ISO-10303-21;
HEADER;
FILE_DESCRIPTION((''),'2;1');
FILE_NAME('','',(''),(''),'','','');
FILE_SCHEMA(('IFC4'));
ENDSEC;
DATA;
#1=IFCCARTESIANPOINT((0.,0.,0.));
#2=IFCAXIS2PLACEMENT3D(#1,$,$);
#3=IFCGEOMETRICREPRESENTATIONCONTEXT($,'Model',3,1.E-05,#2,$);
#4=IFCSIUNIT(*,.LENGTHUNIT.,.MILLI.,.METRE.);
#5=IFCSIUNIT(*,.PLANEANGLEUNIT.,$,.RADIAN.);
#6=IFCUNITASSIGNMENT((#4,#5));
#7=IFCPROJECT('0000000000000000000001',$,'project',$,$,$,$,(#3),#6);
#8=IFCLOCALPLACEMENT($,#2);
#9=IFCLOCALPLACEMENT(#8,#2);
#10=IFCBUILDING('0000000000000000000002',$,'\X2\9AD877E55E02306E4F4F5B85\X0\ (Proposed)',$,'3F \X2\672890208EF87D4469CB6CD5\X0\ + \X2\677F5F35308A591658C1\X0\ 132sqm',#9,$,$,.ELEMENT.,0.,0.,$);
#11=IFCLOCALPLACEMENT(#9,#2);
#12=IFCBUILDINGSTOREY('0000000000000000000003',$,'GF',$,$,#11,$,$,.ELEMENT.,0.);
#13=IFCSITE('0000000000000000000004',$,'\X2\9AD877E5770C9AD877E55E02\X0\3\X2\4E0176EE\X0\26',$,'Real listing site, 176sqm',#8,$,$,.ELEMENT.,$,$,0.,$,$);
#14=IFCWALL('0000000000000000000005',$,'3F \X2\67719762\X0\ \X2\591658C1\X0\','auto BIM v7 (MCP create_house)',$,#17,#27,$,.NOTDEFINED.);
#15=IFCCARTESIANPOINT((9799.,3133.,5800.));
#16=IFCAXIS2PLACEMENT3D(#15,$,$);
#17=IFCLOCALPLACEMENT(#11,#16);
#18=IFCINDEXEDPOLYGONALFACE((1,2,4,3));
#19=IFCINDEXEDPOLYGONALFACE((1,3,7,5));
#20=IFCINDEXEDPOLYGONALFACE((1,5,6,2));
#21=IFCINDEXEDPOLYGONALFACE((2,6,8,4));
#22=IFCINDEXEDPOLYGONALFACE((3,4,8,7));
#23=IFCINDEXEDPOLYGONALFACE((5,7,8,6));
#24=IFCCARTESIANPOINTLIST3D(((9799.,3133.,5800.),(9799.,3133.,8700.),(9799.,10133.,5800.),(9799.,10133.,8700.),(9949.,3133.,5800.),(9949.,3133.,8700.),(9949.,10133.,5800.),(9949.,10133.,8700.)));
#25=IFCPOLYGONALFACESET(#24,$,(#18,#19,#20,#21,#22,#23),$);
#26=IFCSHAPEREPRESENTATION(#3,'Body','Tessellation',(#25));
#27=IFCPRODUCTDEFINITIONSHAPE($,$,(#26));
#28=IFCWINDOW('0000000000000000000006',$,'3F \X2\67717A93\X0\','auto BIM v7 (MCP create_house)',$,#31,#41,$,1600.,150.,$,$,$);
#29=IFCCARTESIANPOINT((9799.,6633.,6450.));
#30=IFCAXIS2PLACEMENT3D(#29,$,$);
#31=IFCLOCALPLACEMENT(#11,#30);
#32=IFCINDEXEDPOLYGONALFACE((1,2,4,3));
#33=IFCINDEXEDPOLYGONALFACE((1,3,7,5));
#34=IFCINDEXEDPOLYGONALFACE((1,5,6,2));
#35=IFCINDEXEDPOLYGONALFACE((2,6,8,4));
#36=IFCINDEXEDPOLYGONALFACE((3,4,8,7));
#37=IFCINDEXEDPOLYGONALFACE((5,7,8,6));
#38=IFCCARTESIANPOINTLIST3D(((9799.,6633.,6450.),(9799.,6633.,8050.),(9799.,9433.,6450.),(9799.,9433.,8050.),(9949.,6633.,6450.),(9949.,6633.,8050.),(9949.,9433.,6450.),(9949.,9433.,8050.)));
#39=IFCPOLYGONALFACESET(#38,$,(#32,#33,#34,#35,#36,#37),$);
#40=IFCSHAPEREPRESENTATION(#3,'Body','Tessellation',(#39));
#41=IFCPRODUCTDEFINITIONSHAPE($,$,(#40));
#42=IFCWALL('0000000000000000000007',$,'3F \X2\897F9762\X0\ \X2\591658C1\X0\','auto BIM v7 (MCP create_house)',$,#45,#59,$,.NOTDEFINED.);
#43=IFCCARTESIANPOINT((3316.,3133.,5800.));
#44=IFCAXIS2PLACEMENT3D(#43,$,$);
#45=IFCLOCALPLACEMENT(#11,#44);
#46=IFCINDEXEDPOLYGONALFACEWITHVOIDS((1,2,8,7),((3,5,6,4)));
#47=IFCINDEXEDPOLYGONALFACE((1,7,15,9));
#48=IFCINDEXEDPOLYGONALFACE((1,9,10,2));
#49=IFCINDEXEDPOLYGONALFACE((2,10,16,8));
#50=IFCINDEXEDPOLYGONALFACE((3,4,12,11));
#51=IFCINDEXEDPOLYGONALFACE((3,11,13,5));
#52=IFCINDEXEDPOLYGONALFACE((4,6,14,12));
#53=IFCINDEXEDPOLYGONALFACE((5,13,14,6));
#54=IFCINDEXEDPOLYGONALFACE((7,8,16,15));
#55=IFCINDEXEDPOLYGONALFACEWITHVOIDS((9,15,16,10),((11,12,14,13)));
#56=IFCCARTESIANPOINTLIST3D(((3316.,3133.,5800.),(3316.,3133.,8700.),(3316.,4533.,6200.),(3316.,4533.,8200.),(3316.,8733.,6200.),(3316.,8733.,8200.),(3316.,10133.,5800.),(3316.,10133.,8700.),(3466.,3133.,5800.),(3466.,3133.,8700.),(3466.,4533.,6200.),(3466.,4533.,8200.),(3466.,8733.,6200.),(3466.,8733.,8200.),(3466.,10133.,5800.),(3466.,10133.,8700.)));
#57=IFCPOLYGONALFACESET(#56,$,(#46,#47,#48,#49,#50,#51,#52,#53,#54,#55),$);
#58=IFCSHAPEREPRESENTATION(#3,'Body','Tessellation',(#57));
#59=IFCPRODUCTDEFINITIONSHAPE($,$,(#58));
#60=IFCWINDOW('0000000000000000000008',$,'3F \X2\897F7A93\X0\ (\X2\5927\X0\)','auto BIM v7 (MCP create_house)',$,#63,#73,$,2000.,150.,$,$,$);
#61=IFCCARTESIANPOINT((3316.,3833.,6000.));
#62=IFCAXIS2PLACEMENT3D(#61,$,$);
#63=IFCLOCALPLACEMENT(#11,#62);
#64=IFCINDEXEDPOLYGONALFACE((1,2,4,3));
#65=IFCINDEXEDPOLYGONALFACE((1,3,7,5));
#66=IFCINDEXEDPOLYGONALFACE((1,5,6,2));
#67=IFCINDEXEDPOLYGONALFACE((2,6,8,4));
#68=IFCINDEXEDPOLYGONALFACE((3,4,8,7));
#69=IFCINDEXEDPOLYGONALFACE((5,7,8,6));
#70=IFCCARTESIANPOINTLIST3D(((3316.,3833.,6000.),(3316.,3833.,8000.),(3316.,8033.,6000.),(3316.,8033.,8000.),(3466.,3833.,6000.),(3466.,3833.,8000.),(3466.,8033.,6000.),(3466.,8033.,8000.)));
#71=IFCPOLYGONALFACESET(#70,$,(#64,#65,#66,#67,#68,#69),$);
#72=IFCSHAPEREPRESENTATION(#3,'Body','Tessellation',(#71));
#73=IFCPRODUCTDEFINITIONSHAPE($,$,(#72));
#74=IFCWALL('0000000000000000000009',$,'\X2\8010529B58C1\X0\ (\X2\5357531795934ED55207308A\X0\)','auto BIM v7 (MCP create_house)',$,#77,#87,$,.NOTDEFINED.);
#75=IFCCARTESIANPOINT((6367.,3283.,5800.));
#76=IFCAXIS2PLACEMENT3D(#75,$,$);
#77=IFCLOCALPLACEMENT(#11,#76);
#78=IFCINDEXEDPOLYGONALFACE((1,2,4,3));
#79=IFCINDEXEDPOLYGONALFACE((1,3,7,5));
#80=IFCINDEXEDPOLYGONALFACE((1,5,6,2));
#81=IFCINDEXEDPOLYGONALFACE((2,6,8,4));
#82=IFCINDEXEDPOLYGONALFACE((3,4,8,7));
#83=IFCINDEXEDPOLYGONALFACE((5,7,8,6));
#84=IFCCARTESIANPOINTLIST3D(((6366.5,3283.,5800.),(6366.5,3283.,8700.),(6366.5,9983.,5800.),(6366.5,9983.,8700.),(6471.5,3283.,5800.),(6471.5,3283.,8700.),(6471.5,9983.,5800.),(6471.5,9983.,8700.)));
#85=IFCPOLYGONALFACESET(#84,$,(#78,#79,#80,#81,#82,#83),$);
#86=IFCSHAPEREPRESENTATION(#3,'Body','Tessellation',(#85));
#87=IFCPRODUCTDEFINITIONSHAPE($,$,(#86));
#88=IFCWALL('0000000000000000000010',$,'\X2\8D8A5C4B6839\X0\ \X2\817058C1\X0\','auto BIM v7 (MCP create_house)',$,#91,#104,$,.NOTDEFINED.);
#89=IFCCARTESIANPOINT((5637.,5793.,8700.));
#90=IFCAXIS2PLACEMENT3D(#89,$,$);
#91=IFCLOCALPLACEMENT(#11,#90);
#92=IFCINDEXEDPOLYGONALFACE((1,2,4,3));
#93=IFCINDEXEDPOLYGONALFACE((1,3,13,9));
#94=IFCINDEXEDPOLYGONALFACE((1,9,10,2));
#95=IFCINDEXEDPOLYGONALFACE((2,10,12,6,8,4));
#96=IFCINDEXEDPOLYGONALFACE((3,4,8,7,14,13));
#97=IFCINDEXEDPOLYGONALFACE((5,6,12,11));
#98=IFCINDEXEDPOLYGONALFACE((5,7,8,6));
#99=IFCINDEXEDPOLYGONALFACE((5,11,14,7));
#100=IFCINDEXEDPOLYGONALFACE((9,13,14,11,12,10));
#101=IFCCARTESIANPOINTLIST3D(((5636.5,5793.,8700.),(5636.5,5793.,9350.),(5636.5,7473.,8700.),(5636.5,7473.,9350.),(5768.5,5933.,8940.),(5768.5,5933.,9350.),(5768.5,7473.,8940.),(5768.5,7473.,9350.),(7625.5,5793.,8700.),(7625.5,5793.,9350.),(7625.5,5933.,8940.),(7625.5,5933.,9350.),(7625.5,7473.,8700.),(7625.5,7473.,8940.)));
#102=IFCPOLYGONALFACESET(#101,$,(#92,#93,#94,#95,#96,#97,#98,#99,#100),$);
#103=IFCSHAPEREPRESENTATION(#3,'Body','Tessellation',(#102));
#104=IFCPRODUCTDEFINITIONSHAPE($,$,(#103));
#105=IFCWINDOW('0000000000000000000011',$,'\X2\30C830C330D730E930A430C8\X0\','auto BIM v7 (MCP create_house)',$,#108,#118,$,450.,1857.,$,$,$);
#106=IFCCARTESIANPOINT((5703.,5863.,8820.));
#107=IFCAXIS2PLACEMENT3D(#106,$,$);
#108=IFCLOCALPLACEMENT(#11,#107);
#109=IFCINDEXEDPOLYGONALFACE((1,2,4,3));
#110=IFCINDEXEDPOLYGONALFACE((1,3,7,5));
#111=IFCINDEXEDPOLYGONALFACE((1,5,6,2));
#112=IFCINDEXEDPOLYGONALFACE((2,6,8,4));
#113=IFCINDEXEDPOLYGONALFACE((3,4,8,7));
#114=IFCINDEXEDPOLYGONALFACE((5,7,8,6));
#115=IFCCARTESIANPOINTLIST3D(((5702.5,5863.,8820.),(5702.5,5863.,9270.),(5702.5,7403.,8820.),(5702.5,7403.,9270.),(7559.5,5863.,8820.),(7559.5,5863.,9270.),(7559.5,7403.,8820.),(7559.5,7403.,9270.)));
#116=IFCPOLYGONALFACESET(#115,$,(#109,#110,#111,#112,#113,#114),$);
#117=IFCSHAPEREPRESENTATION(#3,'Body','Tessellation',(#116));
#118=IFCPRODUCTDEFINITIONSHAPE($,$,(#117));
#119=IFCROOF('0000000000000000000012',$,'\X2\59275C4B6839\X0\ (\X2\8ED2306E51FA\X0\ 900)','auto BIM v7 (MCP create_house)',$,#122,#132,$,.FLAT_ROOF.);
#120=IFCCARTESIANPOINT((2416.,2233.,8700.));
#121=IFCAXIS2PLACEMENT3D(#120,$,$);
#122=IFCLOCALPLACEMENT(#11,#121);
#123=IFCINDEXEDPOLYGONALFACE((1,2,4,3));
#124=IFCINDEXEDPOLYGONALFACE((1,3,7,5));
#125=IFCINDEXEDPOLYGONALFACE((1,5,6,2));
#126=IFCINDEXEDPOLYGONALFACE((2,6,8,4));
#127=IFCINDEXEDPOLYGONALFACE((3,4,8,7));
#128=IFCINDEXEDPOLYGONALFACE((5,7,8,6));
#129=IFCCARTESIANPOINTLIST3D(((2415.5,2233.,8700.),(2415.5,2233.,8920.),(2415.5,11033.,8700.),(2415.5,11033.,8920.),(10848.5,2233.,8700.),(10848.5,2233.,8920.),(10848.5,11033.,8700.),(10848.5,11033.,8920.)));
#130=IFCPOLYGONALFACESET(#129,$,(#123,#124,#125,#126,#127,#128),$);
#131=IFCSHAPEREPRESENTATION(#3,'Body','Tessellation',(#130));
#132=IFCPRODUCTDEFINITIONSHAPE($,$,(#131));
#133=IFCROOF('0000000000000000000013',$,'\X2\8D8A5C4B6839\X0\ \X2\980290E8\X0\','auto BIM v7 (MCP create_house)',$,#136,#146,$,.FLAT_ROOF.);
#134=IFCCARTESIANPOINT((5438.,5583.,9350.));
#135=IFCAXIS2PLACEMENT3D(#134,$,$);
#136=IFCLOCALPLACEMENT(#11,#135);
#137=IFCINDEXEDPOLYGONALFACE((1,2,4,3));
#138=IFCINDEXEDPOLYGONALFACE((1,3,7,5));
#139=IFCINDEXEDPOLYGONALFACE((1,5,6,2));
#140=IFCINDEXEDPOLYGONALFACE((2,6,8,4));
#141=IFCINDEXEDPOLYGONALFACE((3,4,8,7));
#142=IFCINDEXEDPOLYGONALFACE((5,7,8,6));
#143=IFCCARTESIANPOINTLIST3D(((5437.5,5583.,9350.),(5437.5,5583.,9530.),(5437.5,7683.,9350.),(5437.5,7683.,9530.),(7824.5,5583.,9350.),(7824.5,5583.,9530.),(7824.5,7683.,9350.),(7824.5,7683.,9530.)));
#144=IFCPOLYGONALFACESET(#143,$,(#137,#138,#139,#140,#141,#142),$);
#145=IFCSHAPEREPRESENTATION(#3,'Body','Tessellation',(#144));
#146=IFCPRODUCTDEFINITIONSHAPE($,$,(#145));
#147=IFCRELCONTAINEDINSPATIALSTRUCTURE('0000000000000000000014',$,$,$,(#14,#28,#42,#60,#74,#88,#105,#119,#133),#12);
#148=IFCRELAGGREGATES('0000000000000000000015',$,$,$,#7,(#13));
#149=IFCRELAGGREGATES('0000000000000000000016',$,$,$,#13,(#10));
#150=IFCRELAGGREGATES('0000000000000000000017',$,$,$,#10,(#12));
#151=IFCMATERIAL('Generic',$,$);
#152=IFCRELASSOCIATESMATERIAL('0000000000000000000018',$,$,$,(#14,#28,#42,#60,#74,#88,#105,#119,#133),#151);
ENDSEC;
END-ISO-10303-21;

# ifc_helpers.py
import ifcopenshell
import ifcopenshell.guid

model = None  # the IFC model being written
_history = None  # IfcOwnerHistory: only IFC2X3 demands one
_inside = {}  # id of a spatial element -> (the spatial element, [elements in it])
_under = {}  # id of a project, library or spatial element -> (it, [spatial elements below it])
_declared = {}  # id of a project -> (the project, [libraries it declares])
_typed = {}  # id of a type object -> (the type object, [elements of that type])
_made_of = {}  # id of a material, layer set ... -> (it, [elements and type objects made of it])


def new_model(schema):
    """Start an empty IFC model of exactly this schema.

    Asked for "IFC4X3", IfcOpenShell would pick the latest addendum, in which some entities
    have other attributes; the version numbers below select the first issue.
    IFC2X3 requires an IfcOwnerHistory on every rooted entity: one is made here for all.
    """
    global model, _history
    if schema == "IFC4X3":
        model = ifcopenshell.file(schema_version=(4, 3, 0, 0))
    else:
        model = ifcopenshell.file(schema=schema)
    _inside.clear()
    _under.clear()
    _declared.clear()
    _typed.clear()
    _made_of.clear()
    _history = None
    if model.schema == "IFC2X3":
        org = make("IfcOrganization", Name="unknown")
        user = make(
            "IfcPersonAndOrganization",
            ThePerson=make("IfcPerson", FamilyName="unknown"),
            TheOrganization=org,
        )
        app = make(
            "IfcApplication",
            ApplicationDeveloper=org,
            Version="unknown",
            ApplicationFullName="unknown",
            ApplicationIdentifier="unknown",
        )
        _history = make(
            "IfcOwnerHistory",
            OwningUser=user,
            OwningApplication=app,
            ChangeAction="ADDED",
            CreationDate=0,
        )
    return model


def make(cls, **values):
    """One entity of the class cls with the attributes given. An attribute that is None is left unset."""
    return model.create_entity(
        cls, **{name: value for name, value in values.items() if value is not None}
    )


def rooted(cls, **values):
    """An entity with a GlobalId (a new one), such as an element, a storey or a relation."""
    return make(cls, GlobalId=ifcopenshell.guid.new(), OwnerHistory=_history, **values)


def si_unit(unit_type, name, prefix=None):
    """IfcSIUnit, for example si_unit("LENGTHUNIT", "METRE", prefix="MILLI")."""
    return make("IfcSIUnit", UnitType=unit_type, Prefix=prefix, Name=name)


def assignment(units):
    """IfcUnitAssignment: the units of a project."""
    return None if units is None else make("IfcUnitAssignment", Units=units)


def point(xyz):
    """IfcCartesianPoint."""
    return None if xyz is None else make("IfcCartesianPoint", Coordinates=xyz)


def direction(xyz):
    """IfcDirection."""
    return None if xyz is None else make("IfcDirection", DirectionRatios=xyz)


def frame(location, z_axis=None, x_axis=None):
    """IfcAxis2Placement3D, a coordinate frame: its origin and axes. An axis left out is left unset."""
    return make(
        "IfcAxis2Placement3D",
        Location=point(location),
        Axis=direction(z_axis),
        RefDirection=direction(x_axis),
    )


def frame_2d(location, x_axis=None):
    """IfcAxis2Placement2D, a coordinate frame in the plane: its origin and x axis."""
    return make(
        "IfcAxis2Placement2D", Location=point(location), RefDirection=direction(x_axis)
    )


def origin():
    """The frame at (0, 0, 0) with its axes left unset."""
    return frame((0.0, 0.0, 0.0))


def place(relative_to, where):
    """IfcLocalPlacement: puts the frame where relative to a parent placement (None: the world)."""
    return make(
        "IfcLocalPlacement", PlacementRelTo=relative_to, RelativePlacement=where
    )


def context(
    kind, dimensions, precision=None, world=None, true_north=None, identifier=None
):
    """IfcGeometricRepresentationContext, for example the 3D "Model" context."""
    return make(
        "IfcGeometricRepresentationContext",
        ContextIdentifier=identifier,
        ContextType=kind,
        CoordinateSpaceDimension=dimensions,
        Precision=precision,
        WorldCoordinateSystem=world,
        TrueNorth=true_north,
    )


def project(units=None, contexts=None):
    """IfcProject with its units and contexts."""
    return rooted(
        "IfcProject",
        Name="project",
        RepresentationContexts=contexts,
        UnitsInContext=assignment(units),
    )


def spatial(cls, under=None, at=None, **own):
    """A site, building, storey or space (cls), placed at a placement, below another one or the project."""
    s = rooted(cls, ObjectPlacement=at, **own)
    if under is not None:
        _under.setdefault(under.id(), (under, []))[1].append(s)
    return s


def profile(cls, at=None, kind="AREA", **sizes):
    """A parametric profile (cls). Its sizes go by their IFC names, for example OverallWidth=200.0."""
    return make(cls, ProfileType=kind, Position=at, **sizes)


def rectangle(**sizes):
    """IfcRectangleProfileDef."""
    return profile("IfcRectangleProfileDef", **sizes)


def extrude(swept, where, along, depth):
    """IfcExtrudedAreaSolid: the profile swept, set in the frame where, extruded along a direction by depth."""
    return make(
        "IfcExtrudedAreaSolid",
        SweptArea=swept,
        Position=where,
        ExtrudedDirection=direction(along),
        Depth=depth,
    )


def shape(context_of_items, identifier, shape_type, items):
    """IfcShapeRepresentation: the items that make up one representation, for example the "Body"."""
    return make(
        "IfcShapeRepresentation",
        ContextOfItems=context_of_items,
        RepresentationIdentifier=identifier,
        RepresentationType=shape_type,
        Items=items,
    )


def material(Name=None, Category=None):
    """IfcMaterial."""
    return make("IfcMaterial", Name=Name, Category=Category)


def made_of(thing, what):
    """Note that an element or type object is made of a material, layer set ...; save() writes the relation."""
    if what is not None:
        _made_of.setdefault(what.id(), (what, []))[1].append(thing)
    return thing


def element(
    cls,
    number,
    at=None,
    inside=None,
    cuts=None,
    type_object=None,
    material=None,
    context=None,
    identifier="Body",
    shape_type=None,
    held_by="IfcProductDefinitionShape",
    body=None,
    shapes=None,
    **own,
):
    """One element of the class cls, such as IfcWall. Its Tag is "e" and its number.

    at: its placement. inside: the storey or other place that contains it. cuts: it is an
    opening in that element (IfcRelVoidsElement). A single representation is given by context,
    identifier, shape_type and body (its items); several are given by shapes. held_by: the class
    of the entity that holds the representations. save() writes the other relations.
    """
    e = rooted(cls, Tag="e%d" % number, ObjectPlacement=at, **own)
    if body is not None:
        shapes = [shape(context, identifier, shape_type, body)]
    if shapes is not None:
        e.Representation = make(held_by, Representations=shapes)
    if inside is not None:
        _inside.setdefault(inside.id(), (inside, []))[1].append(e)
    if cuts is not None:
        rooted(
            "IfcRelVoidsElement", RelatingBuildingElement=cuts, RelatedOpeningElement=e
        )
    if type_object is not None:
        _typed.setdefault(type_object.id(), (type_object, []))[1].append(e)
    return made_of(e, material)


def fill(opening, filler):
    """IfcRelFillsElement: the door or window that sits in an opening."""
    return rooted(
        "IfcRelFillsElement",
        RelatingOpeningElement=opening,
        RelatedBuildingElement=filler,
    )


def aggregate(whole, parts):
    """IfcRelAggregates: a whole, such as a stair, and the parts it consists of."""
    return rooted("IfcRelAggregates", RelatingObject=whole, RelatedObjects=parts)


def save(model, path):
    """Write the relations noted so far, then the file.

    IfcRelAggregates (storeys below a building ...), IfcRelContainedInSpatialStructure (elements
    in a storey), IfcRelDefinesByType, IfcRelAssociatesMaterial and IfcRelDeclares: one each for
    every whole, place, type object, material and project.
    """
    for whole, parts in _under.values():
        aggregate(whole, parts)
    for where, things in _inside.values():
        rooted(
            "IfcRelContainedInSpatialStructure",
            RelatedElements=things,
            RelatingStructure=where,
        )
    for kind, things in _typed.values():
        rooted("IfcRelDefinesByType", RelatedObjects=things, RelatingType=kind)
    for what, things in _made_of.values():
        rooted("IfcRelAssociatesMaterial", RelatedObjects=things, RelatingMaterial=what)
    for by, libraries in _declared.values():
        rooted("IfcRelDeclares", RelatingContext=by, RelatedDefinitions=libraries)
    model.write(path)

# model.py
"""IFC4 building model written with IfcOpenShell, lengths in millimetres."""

from ifc_helpers import new_model, si_unit, frame, frame_2d, origin, place, context, project, spatial, rectangle, extrude, material, element, fill, save


model = new_model("IFC4")

# Units and contexts
model_context = context("Model", 3, precision=1e-05, world=origin())
ifc_project = project(units=[si_unit("LENGTHUNIT", "METRE", prefix="MILLI"), si_unit("PLANEANGLEUNIT", "RADIAN")], contexts=[model_context])

# Site, building, storey
site_placement = place(None, origin())
site = spatial("IfcSite", under=ifc_project, at=site_placement, Name="高知県高知市3丁目26", ObjectType="Real listing site, 176sqm", CompositionType="ELEMENT", RefElevation=0.0)
building_placement = place(site_placement, origin())
building = spatial("IfcBuilding", under=site, at=building_placement, Name="高知市の住宅 (Proposed)", ObjectType="3F 木造軸組構法 + 板張り外壁 132sqm", CompositionType="ELEMENT", ElevationOfRefHeight=0.0, ElevationOfTerrain=0.0)
storey_placement = place(building_placement, origin())
storey = spatial("IfcBuildingStorey", under=building, at=storey_placement, Name="GF", CompositionType="ELEMENT", Elevation=0.0)

# Shared definitions
ifc_material = material(Name="Generic")

# Walls, openings, windows
wall_1_placement = place(storey_placement, frame((9799.0, 3133.0, 5800.0)))
wall_1 = element("IfcWall", 1, at=wall_1_placement, inside=storey, material=ifc_material, Name="3F 東面 外壁", Description="auto BIM v7 (MCP create_house)", PredefinedType="NOTDEFINED", context=model_context, shape_type="SweptSolid", body=[
    extrude(rectangle(XDim=150.0, YDim=7000.0, at=frame_2d((75.0, 3500.0))), frame((9799.0, 3133.0, 5800.0)), (0.0, 0.0, 1.0), 2900.0),
])
opening_1_placement = place(storey_placement, frame((9799.0, 6633.0, 6450.0)))
opening_1 = element("IfcOpeningElement", 2, at=opening_1_placement, cuts=wall_1, PredefinedType="NOTDEFINED", context=model_context, shape_type="SweptSolid", body=[
    extrude(rectangle(XDim=150.0, YDim=2800.0, at=frame_2d((75.0, 1400.0))), frame((9799.0, 6633.0, 6450.0)), (0.0, 0.0, 1.0), 1600.0),
])
window_1_placement = place(storey_placement, frame((9799.0, 6633.0, 6450.0)))
window_1 = element("IfcWindow", 3, at=window_1_placement, inside=storey, material=ifc_material, Name="3F 東窓", Description="auto BIM v7 (MCP create_house)", OverallHeight=1600.0, OverallWidth=150.0, context=model_context, shape_type="SweptSolid", body=[
    extrude(rectangle(XDim=150.0, YDim=2800.0, at=frame_2d((75.0, 1400.0))), frame((9799.0, 6633.0, 6450.0)), (0.0, 0.0, 1.0), 1600.0),
])
fill(opening_1, window_1)
wall_2_placement = place(storey_placement, frame((3316.0, 3133.0, 5800.0)))
wall_2 = element("IfcWall", 4, at=wall_2_placement, inside=storey, material=ifc_material, Name="3F 西面 外壁", Description="auto BIM v7 (MCP create_house)", PredefinedType="NOTDEFINED", context=model_context, shape_type="SweptSolid", body=[
    extrude(rectangle(XDim=150.0, YDim=7000.0, at=frame_2d((75.0, 3500.0))), frame((3316.0, 3133.0, 5800.0)), (0.0, 0.0, 1.0), 2900.0),
])
opening_2_placement = place(storey_placement, frame((3316.0, 3833.0, 6000.0)))
opening_2 = element("IfcOpeningElement", 5, at=opening_2_placement, cuts=wall_2, PredefinedType="NOTDEFINED", context=model_context, shape_type="SweptSolid", body=[
    extrude(rectangle(XDim=150.0, YDim=4200.0, at=frame_2d((75.0, 2100.0))), frame((3316.0, 3833.0, 6000.0)), (0.0, 0.0, 1.0), 2000.0),
])
window_2_placement = place(storey_placement, frame((3316.0, 3833.0, 6000.0)))
window_2 = element("IfcWindow", 6, at=window_2_placement, inside=storey, material=ifc_material, Name="3F 西窓 (大)", Description="auto BIM v7 (MCP create_house)", OverallHeight=2000.0, OverallWidth=150.0, context=model_context, shape_type="SweptSolid", body=[
    extrude(rectangle(XDim=150.0, YDim=4200.0, at=frame_2d((75.0, 2100.0))), frame((3316.0, 3833.0, 6000.0)), (0.0, 0.0, 1.0), 2000.0),
])
fill(opening_2, window_2)

# Wall
wall_3_placement = place(storey_placement, frame((6367.0, 3283.0, 5800.0)))
element("IfcWall", 7, at=wall_3_placement, inside=storey, material=ifc_material, Name="耐力壁 (南北間仕切り)", Description="auto BIM v7 (MCP create_house)", PredefinedType="NOTDEFINED", context=model_context, shape_type="SweptSolid", body=[
    extrude(rectangle(XDim=105.0, YDim=6700.0, at=frame_2d((52.0, 3350.0))), frame((6367.0, 3283.0, 5800.0)), (0.0, 0.0, 1.0), 2900.0),
])

# Wall, opening, window
wall_4_placement = place(storey_placement, frame((5637.0, 5793.0, 8700.0)))
wall_4 = element("IfcWall", 8, at=wall_4_placement, inside=storey, material=ifc_material, Name="越屋根 腰壁", Description="auto BIM v7 (MCP create_house)", PredefinedType="NOTDEFINED", context=model_context, shape_type="SweptSolid", body=[
    extrude(rectangle(XDim=1989.0, YDim=1680.0, at=frame_2d((994.0, 840.0))), frame((5637.0, 5793.0, 8700.0)), (0.0, 0.0, 1.0), 650.0),
])
opening_3_placement = place(storey_placement, frame((5703.0, 5863.0, 8820.0)))
opening_3 = element("IfcOpeningElement", 9, at=opening_3_placement, cuts=wall_4, PredefinedType="NOTDEFINED", context=model_context, shape_type="SweptSolid", body=[
    extrude(rectangle(XDim=1857.0, YDim=1540.0, at=frame_2d((928.0, 770.0))), frame((5703.0, 5863.0, 8820.0)), (0.0, 0.0, 1.0), 450.0),
])
window_3_placement = place(storey_placement, frame((5703.0, 5863.0, 8820.0)))
window_3 = element("IfcWindow", 10, at=window_3_placement, inside=storey, material=ifc_material, Name="トップライト", Description="auto BIM v7 (MCP create_house)", OverallHeight=450.0, OverallWidth=1857.0, context=model_context, shape_type="SweptSolid", body=[
    extrude(rectangle(XDim=1857.0, YDim=1540.0, at=frame_2d((928.0, 770.0))), frame((5703.0, 5863.0, 8820.0)), (0.0, 0.0, 1.0), 450.0),
])
fill(opening_3, window_3)

# Roofs
roof_1_placement = place(storey_placement, frame((2416.0, 2233.0, 8700.0)))
element("IfcRoof", 11, at=roof_1_placement, inside=storey, material=ifc_material, Name="大屋根 (軒の出 900)", Description="auto BIM v7 (MCP create_house)", PredefinedType="FLAT_ROOF", context=model_context, shape_type="SweptSolid", body=[
    extrude(rectangle(XDim=8433.0, YDim=8800.0, at=frame_2d((4216.0, 4400.0))), frame((2416.0, 2233.0, 8700.0)), (0.0, 0.0, 1.0), 220.0),
])
roof_2_placement = place(storey_placement, frame((5438.0, 5583.0, 9350.0)))
element("IfcRoof", 12, at=roof_2_placement, inside=storey, material=ifc_material, Name="越屋根 頂部", Description="auto BIM v7 (MCP create_house)", PredefinedType="FLAT_ROOF", context=model_context, shape_type="SweptSolid", body=[
    extrude(rectangle(XDim=2387.0, YDim=2100.0, at=frame_2d((1193.0, 1050.0))), frame((5438.0, 5583.0, 9350.0)), (0.0, 0.0, 1.0), 180.0),
])

save(model, "model.ifc")
